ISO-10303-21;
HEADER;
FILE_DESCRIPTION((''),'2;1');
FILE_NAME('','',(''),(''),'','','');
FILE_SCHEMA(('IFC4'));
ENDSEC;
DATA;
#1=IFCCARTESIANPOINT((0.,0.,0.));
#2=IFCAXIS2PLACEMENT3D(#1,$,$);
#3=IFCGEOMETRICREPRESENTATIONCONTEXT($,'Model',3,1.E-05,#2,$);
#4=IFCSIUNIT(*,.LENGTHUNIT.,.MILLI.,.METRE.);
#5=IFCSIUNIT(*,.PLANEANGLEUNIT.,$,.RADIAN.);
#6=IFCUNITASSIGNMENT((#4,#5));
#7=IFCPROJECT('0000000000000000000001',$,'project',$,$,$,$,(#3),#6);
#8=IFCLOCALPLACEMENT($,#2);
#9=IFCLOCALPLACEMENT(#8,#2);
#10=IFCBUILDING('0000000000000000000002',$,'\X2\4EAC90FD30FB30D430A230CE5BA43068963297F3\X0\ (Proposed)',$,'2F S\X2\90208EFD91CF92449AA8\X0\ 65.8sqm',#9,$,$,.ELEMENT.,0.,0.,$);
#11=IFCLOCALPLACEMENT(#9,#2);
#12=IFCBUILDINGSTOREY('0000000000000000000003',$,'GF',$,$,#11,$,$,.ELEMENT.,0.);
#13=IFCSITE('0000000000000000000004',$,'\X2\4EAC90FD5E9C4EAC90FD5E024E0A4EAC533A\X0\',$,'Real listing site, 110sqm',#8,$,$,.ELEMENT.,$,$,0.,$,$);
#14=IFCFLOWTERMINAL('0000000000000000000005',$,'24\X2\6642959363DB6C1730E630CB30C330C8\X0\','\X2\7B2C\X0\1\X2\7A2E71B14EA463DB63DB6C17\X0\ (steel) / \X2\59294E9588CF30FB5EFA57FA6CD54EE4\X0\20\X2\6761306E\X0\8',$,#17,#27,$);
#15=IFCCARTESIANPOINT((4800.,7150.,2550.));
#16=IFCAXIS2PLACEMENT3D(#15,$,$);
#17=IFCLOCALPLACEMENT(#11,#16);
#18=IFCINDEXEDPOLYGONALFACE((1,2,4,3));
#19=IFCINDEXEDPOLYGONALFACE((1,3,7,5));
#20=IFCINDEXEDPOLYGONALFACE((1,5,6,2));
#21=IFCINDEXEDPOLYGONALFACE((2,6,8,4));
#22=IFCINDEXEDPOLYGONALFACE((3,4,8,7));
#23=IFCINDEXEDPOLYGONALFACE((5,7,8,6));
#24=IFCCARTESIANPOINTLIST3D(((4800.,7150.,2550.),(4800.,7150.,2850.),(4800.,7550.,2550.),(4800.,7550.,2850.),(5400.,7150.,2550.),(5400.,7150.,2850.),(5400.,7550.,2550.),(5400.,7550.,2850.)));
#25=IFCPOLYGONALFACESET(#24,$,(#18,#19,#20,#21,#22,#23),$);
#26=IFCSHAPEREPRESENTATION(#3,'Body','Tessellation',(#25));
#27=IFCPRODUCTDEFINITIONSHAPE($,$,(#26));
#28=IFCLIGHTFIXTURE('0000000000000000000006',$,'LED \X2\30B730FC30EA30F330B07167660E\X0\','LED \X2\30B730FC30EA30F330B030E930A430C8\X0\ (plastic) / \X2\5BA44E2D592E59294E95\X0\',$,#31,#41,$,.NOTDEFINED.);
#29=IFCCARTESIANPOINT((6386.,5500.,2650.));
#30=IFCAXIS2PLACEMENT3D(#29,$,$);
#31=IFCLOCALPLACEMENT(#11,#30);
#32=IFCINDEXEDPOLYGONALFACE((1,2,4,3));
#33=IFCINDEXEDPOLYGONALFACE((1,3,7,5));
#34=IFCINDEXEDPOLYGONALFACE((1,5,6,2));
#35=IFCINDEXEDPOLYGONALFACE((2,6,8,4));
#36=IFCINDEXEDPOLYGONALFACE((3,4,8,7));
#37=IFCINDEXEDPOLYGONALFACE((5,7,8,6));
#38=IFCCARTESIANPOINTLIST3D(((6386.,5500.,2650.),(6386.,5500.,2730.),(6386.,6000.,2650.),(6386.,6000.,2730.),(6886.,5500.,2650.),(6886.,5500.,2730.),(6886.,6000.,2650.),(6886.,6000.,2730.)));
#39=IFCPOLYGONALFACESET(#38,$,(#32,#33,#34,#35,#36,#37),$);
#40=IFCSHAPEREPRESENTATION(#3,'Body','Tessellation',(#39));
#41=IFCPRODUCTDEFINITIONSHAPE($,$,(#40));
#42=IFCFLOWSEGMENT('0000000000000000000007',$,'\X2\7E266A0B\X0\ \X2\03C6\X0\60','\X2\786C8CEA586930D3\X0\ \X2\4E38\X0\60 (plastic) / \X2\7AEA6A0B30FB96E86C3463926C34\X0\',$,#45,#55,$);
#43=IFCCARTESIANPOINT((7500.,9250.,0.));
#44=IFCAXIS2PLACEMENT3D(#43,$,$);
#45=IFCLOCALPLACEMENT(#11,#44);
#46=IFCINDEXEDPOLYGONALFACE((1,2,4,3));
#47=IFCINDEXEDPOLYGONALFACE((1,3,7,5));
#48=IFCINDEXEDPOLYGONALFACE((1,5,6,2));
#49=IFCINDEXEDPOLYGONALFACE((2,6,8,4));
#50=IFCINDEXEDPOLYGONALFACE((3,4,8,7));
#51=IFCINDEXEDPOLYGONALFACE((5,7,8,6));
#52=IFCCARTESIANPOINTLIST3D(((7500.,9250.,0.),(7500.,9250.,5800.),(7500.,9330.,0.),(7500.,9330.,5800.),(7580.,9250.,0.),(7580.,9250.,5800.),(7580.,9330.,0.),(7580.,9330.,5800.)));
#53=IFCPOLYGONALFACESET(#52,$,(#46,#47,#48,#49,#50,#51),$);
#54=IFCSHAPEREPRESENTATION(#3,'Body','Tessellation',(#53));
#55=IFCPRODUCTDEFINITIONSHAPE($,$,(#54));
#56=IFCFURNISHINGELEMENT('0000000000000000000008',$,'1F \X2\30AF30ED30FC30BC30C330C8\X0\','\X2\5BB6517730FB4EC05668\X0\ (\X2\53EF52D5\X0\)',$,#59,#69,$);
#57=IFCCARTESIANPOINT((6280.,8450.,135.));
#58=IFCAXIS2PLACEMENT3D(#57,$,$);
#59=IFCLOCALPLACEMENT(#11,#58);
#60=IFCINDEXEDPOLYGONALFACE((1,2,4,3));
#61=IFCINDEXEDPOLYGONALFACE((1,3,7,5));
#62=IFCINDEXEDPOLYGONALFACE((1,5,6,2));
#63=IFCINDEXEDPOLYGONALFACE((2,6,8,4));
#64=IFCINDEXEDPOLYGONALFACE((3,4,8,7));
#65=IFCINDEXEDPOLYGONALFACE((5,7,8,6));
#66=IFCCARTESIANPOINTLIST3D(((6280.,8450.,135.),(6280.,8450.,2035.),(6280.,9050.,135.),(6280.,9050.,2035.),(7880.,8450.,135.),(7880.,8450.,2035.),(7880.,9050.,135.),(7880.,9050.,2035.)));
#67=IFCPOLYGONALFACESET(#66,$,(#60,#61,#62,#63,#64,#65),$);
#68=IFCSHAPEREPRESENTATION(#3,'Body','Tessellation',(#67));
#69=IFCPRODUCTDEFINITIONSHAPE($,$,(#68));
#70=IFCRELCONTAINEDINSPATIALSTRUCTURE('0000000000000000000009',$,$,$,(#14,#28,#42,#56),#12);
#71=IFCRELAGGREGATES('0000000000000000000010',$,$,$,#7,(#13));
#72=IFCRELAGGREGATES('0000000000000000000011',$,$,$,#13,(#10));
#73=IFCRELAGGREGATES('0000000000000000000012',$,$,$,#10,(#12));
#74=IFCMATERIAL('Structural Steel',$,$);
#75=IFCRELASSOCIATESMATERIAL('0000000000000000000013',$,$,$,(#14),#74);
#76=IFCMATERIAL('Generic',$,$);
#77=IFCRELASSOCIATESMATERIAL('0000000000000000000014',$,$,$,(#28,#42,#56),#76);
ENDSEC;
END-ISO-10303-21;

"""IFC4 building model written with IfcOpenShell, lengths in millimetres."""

from ifc_helpers import new_model, si_unit, frame, frame_2d, origin, place, context, project, spatial, rectangle, extrude, material, element, save


model = new_model("IFC4")

# Units and contexts
model_context = context("Model", 3, precision=1e-05, world=origin())
ifc_project = project(units=[si_unit("LENGTHUNIT", "METRE", prefix="MILLI"), si_unit("PLANEANGLEUNIT", "RADIAN")], contexts=[model_context])

# Site, building, storey
site_placement = place(None, origin())
site = spatial("IfcSite", under=ifc_project, at=site_placement, Name="京都府京都市上京区", ObjectType="Real listing site, 110sqm", CompositionType="ELEMENT", RefElevation=0.0)
building_placement = place(site_placement, origin())
building = spatial("IfcBuilding", under=site, at=building_placement, Name="京都・ピアノ室と防音 (Proposed)", ObjectType="2F S造軽量鉄骨 65.8sqm", CompositionType="ELEMENT", ElevationOfRefHeight=0.0, ElevationOfTerrain=0.0)
storey_placement = place(building_placement, origin())
storey = spatial("IfcBuildingStorey", under=building, at=storey_placement, Name="GF", CompositionType="ELEMENT", Elevation=0.0)

# Shared definitions
ifc_material_1 = material(Name="Generic")

# Flow terminal
ifc_material_2 = material(Name="Structural Steel")
flow_terminal_placement = place(storey_placement, frame((4800.0, 7150.0, 2550.0)))
element("IfcFlowTerminal", 1, at=flow_terminal_placement, inside=storey, material=ifc_material_2, Name="24時間換気ユニット", Description="第1種熱交換換気 (steel) / 天井裏・建基法令20条の8", context=model_context, shape_type="SweptSolid", body=[
    extrude(rectangle(XDim=600.0, YDim=400.0, at=frame_2d((300.0, 200.0))), frame((4800.0, 7150.0, 2550.0)), (0.0, 0.0, 1.0), 300.0),
])

# Light fixture
light_fixture_placement = place(storey_placement, frame((6386.0, 5500.0, 2650.0)))
element("IfcLightFixture", 2, at=light_fixture_placement, inside=storey, material=ifc_material_1, Name="LED シーリング照明", Description="LED シーリングライト (plastic) / 室中央天井", PredefinedType="NOTDEFINED", context=model_context, shape_type="SweptSolid", body=[
    extrude(rectangle(XDim=500.0, YDim=500.0, at=frame_2d((250.0, 250.0))), frame((6386.0, 5500.0, 2650.0)), (0.0, 0.0, 1.0), 80.0),
])

# Flow segment
flow_segment_placement = place(storey_placement, frame((7500.0, 9250.0, 0.0)))
element("IfcFlowSegment", 3, at=flow_segment_placement, inside=storey, material=ifc_material_1, Name="縦樋 φ60", Description="硬質塩ビ 丸60 (plastic) / 竪樋・雨水排水", context=model_context, shape_type="SweptSolid", body=[
    extrude(rectangle(XDim=80.0, YDim=80.0, at=frame_2d((40.0, 40.0))), frame((7500.0, 9250.0, 0.0)), (0.0, 0.0, 1.0), 5800.0),
])

# Furnishing element
furnishing_placement = place(storey_placement, frame((6280.0, 8450.0, 135.0)))
element("IfcFurnishingElement", 4, at=furnishing_placement, inside=storey, material=ifc_material_1, Name="1F クローゼット", Description="家具・什器 (可動)", context=model_context, shape_type="SweptSolid", body=[
    extrude(rectangle(XDim=1600.0, YDim=600.0, at=frame_2d((800.0, 300.0))), frame((6280.0, 8450.0, 135.0)), (0.0, 0.0, 1.0), 1900.0),
])

save(model, "model.ifc")
